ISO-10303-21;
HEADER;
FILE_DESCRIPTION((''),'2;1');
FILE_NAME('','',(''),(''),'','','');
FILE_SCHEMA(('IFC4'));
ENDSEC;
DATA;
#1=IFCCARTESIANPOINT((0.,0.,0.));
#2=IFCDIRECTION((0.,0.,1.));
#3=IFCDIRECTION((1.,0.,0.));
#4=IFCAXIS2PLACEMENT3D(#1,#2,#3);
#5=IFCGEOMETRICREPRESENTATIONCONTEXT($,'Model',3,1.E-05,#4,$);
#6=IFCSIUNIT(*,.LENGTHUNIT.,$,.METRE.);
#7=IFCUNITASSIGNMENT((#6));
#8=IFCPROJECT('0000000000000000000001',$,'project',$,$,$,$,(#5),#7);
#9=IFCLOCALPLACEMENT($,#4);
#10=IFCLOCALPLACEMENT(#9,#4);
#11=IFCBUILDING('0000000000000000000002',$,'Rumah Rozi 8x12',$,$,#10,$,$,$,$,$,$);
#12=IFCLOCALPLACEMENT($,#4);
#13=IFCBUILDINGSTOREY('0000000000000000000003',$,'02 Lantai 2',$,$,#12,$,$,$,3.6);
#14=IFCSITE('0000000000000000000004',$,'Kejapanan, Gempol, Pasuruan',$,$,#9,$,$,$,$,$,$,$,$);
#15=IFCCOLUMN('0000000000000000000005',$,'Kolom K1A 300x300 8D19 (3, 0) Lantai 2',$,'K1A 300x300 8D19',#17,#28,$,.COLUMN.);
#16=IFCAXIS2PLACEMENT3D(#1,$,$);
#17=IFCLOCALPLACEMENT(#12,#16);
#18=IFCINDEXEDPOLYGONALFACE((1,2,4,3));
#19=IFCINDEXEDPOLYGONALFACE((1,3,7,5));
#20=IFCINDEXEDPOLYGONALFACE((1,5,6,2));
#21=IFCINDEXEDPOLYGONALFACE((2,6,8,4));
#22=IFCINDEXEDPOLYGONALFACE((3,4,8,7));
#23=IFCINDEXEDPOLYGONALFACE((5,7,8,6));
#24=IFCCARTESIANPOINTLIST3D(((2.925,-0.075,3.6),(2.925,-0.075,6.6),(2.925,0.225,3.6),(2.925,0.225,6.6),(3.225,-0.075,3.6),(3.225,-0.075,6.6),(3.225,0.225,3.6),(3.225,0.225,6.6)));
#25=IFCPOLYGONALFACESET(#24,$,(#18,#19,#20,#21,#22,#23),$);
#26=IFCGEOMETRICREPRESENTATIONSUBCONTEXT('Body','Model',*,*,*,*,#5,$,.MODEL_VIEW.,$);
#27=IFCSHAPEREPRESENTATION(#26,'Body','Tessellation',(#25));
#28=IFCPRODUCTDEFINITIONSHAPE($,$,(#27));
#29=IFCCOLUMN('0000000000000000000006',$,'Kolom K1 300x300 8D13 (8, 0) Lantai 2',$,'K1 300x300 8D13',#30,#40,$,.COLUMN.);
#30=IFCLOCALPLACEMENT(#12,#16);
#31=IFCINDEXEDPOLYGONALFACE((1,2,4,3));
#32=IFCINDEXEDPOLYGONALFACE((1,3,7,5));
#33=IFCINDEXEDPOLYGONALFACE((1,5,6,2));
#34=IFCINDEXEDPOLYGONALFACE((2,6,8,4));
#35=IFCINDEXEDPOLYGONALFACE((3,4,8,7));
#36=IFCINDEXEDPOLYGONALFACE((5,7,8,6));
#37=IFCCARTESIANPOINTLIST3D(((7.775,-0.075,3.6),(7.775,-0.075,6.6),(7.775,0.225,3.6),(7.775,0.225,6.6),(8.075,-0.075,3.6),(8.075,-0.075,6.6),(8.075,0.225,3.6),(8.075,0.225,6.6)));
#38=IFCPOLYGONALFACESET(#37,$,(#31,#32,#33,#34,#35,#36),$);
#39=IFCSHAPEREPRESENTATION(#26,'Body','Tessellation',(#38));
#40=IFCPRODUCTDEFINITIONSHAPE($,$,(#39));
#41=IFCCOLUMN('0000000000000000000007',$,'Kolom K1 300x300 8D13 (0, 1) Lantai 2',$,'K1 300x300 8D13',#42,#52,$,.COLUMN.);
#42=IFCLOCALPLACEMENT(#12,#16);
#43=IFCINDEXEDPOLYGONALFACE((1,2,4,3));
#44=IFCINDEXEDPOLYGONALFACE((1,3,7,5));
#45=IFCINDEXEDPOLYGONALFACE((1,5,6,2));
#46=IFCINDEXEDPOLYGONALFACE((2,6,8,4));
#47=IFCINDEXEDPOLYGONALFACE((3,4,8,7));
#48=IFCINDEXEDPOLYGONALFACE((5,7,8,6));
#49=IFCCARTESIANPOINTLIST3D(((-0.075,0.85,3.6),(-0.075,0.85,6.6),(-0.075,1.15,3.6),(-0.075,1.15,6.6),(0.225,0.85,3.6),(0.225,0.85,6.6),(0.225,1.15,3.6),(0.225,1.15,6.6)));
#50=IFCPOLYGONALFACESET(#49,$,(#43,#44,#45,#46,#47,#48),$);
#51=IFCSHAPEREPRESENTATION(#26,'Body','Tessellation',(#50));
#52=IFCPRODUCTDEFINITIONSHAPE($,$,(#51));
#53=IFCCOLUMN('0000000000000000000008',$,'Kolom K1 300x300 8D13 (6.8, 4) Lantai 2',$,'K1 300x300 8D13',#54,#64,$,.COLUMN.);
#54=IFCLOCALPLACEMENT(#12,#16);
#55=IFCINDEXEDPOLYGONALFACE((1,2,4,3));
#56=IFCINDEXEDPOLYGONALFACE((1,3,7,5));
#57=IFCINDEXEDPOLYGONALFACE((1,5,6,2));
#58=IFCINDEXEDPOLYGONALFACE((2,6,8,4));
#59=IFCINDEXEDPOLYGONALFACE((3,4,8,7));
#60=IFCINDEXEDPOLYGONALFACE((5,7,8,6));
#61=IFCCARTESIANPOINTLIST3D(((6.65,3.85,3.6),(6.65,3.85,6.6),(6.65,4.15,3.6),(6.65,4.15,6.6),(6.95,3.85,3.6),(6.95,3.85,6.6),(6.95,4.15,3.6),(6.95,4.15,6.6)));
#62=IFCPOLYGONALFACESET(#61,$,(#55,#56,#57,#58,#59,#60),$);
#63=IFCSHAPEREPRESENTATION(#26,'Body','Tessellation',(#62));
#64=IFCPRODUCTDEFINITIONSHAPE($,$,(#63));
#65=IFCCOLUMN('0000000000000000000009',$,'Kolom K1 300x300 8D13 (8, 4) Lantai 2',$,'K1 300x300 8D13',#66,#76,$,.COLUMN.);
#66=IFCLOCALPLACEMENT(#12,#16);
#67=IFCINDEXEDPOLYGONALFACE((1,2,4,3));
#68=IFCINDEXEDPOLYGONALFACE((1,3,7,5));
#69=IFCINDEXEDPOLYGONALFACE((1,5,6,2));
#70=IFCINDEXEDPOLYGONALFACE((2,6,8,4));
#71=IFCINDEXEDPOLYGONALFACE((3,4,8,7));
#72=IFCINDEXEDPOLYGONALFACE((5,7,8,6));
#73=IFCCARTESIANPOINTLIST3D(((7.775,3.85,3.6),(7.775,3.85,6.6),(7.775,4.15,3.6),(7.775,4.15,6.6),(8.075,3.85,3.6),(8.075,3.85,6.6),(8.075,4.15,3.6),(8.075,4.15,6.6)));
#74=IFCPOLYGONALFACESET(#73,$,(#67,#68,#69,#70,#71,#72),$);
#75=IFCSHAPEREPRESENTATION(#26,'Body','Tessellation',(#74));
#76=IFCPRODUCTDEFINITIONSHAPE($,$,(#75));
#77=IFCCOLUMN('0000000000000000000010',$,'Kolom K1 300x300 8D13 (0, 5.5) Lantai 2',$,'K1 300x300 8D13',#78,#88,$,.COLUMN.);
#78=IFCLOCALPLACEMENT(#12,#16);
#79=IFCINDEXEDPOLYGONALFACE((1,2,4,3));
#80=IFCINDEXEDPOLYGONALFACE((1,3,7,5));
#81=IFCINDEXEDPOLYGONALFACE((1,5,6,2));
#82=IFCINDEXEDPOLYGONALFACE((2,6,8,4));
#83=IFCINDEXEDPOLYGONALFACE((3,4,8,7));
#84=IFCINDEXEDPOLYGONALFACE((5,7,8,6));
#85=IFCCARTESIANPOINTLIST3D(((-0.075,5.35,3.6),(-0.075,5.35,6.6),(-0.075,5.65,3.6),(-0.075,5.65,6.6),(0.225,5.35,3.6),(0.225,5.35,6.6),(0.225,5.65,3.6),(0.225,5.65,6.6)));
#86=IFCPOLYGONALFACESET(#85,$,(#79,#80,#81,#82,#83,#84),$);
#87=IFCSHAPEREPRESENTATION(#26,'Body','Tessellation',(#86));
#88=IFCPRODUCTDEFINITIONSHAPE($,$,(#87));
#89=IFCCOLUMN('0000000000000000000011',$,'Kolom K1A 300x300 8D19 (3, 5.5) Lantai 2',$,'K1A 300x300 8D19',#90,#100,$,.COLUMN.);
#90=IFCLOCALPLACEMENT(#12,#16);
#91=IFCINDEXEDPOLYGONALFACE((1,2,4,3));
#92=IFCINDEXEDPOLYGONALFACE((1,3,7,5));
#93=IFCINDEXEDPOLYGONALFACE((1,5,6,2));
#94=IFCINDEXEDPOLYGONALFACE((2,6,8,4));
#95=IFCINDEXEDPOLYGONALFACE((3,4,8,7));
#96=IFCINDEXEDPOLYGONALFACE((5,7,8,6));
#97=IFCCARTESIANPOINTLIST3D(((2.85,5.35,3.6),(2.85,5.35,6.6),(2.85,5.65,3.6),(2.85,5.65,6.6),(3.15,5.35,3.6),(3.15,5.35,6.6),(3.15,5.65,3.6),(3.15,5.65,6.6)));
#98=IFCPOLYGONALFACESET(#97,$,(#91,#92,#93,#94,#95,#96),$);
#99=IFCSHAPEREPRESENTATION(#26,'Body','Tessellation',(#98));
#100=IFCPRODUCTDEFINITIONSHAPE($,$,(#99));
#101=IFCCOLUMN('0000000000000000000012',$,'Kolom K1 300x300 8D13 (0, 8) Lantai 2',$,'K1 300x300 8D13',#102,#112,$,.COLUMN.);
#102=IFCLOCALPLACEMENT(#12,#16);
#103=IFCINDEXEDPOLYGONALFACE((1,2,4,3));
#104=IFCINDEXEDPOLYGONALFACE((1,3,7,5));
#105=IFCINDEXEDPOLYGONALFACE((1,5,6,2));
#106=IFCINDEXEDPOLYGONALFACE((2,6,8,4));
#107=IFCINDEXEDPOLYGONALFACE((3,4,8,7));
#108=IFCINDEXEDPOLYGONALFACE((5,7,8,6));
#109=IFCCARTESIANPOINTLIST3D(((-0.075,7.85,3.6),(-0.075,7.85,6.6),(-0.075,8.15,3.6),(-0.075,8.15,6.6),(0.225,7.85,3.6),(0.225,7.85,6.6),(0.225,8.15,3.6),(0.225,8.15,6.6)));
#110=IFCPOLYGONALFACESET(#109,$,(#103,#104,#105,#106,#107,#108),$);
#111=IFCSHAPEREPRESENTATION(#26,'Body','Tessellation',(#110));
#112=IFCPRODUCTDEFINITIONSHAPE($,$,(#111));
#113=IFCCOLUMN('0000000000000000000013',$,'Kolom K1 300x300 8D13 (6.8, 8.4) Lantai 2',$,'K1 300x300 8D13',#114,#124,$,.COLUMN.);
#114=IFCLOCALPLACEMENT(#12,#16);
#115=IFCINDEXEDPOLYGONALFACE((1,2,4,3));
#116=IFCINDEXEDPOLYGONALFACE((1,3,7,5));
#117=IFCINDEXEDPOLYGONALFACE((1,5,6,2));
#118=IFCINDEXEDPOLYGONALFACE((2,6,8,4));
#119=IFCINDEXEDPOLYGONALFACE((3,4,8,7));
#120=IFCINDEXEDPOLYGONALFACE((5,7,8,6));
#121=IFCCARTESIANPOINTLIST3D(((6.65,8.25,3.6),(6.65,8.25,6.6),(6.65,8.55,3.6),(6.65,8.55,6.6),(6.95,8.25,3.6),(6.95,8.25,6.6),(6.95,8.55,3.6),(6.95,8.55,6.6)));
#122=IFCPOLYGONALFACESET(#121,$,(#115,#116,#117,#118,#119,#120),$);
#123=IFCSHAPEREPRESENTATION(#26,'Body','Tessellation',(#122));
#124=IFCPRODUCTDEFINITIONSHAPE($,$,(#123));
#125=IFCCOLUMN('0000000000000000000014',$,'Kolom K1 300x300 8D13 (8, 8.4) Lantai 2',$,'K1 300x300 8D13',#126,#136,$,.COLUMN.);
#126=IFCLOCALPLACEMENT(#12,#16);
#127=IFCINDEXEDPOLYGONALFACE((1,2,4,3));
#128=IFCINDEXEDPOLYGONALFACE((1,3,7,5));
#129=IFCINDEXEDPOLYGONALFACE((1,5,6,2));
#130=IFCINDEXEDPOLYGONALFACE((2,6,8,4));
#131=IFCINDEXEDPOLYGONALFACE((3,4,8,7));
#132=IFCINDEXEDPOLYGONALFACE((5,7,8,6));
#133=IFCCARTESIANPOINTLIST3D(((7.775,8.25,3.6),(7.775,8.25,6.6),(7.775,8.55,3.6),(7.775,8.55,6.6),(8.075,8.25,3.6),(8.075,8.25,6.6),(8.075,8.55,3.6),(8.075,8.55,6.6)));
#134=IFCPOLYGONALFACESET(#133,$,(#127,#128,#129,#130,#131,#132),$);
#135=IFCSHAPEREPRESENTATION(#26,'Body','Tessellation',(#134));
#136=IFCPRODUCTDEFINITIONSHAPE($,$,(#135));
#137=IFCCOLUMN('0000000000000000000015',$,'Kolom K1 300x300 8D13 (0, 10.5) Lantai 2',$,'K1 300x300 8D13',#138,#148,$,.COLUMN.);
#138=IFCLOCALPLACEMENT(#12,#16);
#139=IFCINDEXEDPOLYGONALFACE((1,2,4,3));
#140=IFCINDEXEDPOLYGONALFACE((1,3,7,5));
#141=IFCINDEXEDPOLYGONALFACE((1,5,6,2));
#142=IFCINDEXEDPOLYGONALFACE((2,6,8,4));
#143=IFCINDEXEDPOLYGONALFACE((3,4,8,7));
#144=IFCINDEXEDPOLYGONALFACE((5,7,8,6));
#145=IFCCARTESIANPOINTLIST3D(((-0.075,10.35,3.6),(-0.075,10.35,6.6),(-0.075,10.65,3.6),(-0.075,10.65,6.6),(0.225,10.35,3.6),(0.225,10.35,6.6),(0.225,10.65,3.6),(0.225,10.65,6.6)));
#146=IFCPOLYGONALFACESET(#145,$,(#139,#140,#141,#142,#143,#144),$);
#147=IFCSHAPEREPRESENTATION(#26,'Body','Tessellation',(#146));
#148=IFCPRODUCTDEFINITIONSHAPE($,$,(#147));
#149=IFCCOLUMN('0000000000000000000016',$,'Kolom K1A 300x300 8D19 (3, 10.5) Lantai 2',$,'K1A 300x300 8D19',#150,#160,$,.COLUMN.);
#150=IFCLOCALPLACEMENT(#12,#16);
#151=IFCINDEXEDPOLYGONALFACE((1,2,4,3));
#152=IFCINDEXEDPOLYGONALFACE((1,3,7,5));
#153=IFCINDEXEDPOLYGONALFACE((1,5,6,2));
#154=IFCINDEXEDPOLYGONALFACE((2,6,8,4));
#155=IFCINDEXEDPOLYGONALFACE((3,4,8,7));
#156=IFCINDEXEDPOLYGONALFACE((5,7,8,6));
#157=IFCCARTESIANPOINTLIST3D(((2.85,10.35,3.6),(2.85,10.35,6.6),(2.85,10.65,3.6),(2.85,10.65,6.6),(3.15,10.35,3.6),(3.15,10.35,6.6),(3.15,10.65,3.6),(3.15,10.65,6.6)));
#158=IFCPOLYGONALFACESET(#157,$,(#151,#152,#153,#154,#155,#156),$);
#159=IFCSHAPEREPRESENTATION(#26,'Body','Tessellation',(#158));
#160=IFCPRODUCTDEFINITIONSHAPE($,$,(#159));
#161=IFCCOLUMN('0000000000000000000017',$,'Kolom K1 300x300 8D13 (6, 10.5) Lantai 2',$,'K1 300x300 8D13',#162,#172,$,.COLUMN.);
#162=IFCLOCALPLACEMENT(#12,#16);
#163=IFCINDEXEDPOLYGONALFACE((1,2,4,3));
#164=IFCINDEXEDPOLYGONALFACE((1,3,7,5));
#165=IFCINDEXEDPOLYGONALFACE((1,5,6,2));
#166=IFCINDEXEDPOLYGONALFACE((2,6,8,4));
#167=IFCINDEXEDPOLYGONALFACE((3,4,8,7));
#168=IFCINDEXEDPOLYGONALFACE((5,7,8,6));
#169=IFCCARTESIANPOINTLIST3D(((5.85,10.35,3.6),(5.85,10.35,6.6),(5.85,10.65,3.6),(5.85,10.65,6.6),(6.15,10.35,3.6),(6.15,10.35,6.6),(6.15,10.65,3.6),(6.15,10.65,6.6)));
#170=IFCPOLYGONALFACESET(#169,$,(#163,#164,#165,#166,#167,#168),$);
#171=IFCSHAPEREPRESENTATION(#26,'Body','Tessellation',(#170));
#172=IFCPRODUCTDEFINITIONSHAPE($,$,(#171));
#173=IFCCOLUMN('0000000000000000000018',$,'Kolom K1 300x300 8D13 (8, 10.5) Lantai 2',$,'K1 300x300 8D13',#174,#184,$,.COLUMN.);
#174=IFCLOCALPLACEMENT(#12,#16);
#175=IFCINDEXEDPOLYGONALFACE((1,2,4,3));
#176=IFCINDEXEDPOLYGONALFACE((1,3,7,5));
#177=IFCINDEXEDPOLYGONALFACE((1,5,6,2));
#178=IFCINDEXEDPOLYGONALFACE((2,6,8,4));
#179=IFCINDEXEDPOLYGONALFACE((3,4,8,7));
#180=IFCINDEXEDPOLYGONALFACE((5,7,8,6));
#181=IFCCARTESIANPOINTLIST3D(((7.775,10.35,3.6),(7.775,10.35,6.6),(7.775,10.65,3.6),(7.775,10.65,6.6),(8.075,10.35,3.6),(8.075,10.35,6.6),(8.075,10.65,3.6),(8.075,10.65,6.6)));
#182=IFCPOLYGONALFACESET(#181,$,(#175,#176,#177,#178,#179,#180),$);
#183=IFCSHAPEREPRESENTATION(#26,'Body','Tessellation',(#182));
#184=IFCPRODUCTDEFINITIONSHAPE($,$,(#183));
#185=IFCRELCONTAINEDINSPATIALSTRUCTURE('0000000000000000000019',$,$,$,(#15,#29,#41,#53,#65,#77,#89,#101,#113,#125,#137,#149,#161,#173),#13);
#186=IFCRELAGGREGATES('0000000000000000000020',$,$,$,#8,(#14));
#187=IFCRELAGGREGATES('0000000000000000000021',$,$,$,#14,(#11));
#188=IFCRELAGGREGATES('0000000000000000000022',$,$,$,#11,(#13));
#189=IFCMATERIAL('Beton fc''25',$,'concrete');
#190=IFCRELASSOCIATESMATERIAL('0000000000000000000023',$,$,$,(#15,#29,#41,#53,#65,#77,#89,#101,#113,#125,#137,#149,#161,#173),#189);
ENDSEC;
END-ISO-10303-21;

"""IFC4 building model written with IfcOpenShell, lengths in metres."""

from ifc_helpers import new_model, si_unit, frame, origin_with_axes, place, context, subcontext, project, spatial, line, indexed_curve, outline, extrude, material, element, save


model = new_model("IFC4")

# Units and contexts
model_context = context("Model", 3, precision=1e-05, world=origin_with_axes())
body_context = subcontext(model_context, "Body", "Model", "MODEL_VIEW")
ifc_project = project(units=[si_unit("LENGTHUNIT", "METRE")], contexts=[model_context])

# Site, building, storey
site_placement = place(None, origin_with_axes())
site = spatial("IfcSite", under=ifc_project, at=site_placement, Name="Kejapanan, Gempol, Pasuruan")
building_placement = place(site_placement, origin_with_axes())
building = spatial("IfcBuilding", under=site, at=building_placement, Name="Rumah Rozi 8x12")
storey_placement = place(None, origin_with_axes())
storey = spatial("IfcBuildingStorey", under=building, at=storey_placement, Name="02 Lantai 2", Elevation=3.6)

# Columns
ifc_material = material(Name="Beton fc'25", Category="concrete")
column_1_placement = place(storey_placement, origin_with_axes())
element("IfcColumn", 1, at=column_1_placement, inside=storey, material=ifc_material, Name="Kolom K1A 300x300 8D19 (3, 0) Lantai 2", ObjectType="K1A 300x300 8D19", PredefinedType="COLUMN", context=body_context, shape_type="SweptSolid", body=[
    extrude(outline(indexed_curve([(2.925, -0.075), (3.225, -0.075), (3.225, 0.225), (2.925, 0.225)], segments=[line(1, 2, 3, 4, 1)])), frame((0.0, 0.0, 3.6), z_axis=(0.0, 0.0, 1.0), x_axis=(1.0, 0.0, 0.0)), (0.0, 0.0, 1.0), 3.0),
])
column_2_placement = place(storey_placement, origin_with_axes())
element("IfcColumn", 2, at=column_2_placement, inside=storey, material=ifc_material, Name="Kolom K1 300x300 8D13 (8, 0) Lantai 2", ObjectType="K1 300x300 8D13", PredefinedType="COLUMN", context=body_context, shape_type="SweptSolid", body=[
    extrude(outline(indexed_curve([(7.775, -0.075), (8.075, -0.075), (8.075, 0.225), (7.775, 0.225)], segments=[line(1, 2, 3, 4, 1)])), frame((0.0, 0.0, 3.6), z_axis=(0.0, 0.0, 1.0), x_axis=(1.0, 0.0, 0.0)), (0.0, 0.0, 1.0), 3.0),
])
column_3_placement = place(storey_placement, origin_with_axes())
element("IfcColumn", 3, at=column_3_placement, inside=storey, material=ifc_material, Name="Kolom K1 300x300 8D13 (0, 1) Lantai 2", ObjectType="K1 300x300 8D13", PredefinedType="COLUMN", context=body_context, shape_type="SweptSolid", body=[
    extrude(outline(indexed_curve([(-0.075, 0.85), (0.225, 0.85), (0.225, 1.15), (-0.075, 1.15)], segments=[line(1, 2, 3, 4, 1)])), frame((0.0, 0.0, 3.6), z_axis=(0.0, 0.0, 1.0), x_axis=(1.0, 0.0, 0.0)), (0.0, 0.0, 1.0), 3.0),
])
column_4_placement = place(storey_placement, origin_with_axes())
element("IfcColumn", 4, at=column_4_placement, inside=storey, material=ifc_material, Name="Kolom K1 300x300 8D13 (6.8, 4) Lantai 2", ObjectType="K1 300x300 8D13", PredefinedType="COLUMN", context=body_context, shape_type="SweptSolid", body=[
    extrude(outline(indexed_curve([(6.65, 3.85), (6.95, 3.85), (6.95, 4.15), (6.65, 4.15)], segments=[line(1, 2, 3, 4, 1)])), frame((0.0, 0.0, 3.6), z_axis=(0.0, 0.0, 1.0), x_axis=(1.0, 0.0, 0.0)), (0.0, 0.0, 1.0), 3.0),
])
column_5_placement = place(storey_placement, origin_with_axes())
element("IfcColumn", 5, at=column_5_placement, inside=storey, material=ifc_material, Name="Kolom K1 300x300 8D13 (8, 4) Lantai 2", ObjectType="K1 300x300 8D13", PredefinedType="COLUMN", context=body_context, shape_type="SweptSolid", body=[
    extrude(outline(indexed_curve([(7.775, 3.85), (8.075, 3.85), (8.075, 4.15), (7.775, 4.15)], segments=[line(1, 2, 3, 4, 1)])), frame((0.0, 0.0, 3.6), z_axis=(0.0, 0.0, 1.0), x_axis=(1.0, 0.0, 0.0)), (0.0, 0.0, 1.0), 3.0),
])
column_6_placement = place(storey_placement, origin_with_axes())
element("IfcColumn", 6, at=column_6_placement, inside=storey, material=ifc_material, Name="Kolom K1 300x300 8D13 (0, 5.5) Lantai 2", ObjectType="K1 300x300 8D13", PredefinedType="COLUMN", context=body_context, shape_type="SweptSolid", body=[
    extrude(outline(indexed_curve([(-0.075, 5.35), (0.225, 5.35), (0.225, 5.65), (-0.075, 5.65)], segments=[line(1, 2, 3, 4, 1)])), frame((0.0, 0.0, 3.6), z_axis=(0.0, 0.0, 1.0), x_axis=(1.0, 0.0, 0.0)), (0.0, 0.0, 1.0), 3.0),
])
column_7_placement = place(storey_placement, origin_with_axes())
element("IfcColumn", 7, at=column_7_placement, inside=storey, material=ifc_material, Name="Kolom K1A 300x300 8D19 (3, 5.5) Lantai 2", ObjectType="K1A 300x300 8D19", PredefinedType="COLUMN", context=body_context, shape_type="SweptSolid", body=[
    extrude(outline(indexed_curve([(2.85, 5.35), (3.15, 5.35), (3.15, 5.65), (2.85, 5.65)], segments=[line(1, 2, 3, 4, 1)])), frame((0.0, 0.0, 3.6), z_axis=(0.0, 0.0, 1.0), x_axis=(1.0, 0.0, 0.0)), (0.0, 0.0, 1.0), 3.0),
])
column_8_placement = place(storey_placement, origin_with_axes())
element("IfcColumn", 8, at=column_8_placement, inside=storey, material=ifc_material, Name="Kolom K1 300x300 8D13 (0, 8) Lantai 2", ObjectType="K1 300x300 8D13", PredefinedType="COLUMN", context=body_context, shape_type="SweptSolid", body=[
    extrude(outline(indexed_curve([(-0.075, 7.85), (0.225, 7.85), (0.225, 8.15), (-0.075, 8.15)], segments=[line(1, 2, 3, 4, 1)])), frame((0.0, 0.0, 3.6), z_axis=(0.0, 0.0, 1.0), x_axis=(1.0, 0.0, 0.0)), (0.0, 0.0, 1.0), 3.0),
])
column_9_placement = place(storey_placement, origin_with_axes())
element("IfcColumn", 9, at=column_9_placement, inside=storey, material=ifc_material, Name="Kolom K1 300x300 8D13 (6.8, 8.4) Lantai 2", ObjectType="K1 300x300 8D13", PredefinedType="COLUMN", context=body_context, shape_type="SweptSolid", body=[
    extrude(outline(indexed_curve([(6.65, 8.25), (6.95, 8.25), (6.95, 8.55), (6.65, 8.55)], segments=[line(1, 2, 3, 4, 1)])), frame((0.0, 0.0, 3.6), z_axis=(0.0, 0.0, 1.0), x_axis=(1.0, 0.0, 0.0)), (0.0, 0.0, 1.0), 3.0),
])
column_10_placement = place(storey_placement, origin_with_axes())
element("IfcColumn", 10, at=column_10_placement, inside=storey, material=ifc_material, Name="Kolom K1 300x300 8D13 (8, 8.4) Lantai 2", ObjectType="K1 300x300 8D13", PredefinedType="COLUMN", context=body_context, shape_type="SweptSolid", body=[
    extrude(outline(indexed_curve([(7.775, 8.25), (8.075, 8.25), (8.075, 8.55), (7.775, 8.55)], segments=[line(1, 2, 3, 4, 1)])), frame((0.0, 0.0, 3.6), z_axis=(0.0, 0.0, 1.0), x_axis=(1.0, 0.0, 0.0)), (0.0, 0.0, 1.0), 3.0),
])
column_11_placement = place(storey_placement, origin_with_axes())
element("IfcColumn", 11, at=column_11_placement, inside=storey, material=ifc_material, Name="Kolom K1 300x300 8D13 (0, 10.5) Lantai 2", ObjectType="K1 300x300 8D13", PredefinedType="COLUMN", context=body_context, shape_type="SweptSolid", body=[
    extrude(outline(indexed_curve([(-0.075, 10.35), (0.225, 10.35), (0.225, 10.65), (-0.075, 10.65)], segments=[line(1, 2, 3, 4, 1)])), frame((0.0, 0.0, 3.6), z_axis=(0.0, 0.0, 1.0), x_axis=(1.0, 0.0, 0.0)), (0.0, 0.0, 1.0), 3.0),
])
column_12_placement = place(storey_placement, origin_with_axes())
element("IfcColumn", 12, at=column_12_placement, inside=storey, material=ifc_material, Name="Kolom K1A 300x300 8D19 (3, 10.5) Lantai 2", ObjectType="K1A 300x300 8D19", PredefinedType="COLUMN", context=body_context, shape_type="SweptSolid", body=[
    extrude(outline(indexed_curve([(2.85, 10.35), (3.15, 10.35), (3.15, 10.65), (2.85, 10.65)], segments=[line(1, 2, 3, 4, 1)])), frame((0.0, 0.0, 3.6), z_axis=(0.0, 0.0, 1.0), x_axis=(1.0, 0.0, 0.0)), (0.0, 0.0, 1.0), 3.0),
])
column_13_placement = place(storey_placement, origin_with_axes())
element("IfcColumn", 13, at=column_13_placement, inside=storey, material=ifc_material, Name="Kolom K1 300x300 8D13 (6, 10.5) Lantai 2", ObjectType="K1 300x300 8D13", PredefinedType="COLUMN", context=body_context, shape_type="SweptSolid", body=[
    extrude(outline(indexed_curve([(5.85, 10.35), (6.15, 10.35), (6.15, 10.65), (5.85, 10.65)], segments=[line(1, 2, 3, 4, 1)])), frame((0.0, 0.0, 3.6), z_axis=(0.0, 0.0, 1.0), x_axis=(1.0, 0.0, 0.0)), (0.0, 0.0, 1.0), 3.0),
])
column_14_placement = place(storey_placement, origin_with_axes())
element("IfcColumn", 14, at=column_14_placement, inside=storey, material=ifc_material, Name="Kolom K1 300x300 8D13 (8, 10.5) Lantai 2", ObjectType="K1 300x300 8D13", PredefinedType="COLUMN", context=body_context, shape_type="SweptSolid", body=[
    extrude(outline(indexed_curve([(7.775, 10.35), (8.075, 10.35), (8.075, 10.65), (7.775, 10.65)], segments=[line(1, 2, 3, 4, 1)])), frame((0.0, 0.0, 3.6), z_axis=(0.0, 0.0, 1.0), x_axis=(1.0, 0.0, 0.0)), (0.0, 0.0, 1.0), 3.0),
])

save(model, "model.ifc")
